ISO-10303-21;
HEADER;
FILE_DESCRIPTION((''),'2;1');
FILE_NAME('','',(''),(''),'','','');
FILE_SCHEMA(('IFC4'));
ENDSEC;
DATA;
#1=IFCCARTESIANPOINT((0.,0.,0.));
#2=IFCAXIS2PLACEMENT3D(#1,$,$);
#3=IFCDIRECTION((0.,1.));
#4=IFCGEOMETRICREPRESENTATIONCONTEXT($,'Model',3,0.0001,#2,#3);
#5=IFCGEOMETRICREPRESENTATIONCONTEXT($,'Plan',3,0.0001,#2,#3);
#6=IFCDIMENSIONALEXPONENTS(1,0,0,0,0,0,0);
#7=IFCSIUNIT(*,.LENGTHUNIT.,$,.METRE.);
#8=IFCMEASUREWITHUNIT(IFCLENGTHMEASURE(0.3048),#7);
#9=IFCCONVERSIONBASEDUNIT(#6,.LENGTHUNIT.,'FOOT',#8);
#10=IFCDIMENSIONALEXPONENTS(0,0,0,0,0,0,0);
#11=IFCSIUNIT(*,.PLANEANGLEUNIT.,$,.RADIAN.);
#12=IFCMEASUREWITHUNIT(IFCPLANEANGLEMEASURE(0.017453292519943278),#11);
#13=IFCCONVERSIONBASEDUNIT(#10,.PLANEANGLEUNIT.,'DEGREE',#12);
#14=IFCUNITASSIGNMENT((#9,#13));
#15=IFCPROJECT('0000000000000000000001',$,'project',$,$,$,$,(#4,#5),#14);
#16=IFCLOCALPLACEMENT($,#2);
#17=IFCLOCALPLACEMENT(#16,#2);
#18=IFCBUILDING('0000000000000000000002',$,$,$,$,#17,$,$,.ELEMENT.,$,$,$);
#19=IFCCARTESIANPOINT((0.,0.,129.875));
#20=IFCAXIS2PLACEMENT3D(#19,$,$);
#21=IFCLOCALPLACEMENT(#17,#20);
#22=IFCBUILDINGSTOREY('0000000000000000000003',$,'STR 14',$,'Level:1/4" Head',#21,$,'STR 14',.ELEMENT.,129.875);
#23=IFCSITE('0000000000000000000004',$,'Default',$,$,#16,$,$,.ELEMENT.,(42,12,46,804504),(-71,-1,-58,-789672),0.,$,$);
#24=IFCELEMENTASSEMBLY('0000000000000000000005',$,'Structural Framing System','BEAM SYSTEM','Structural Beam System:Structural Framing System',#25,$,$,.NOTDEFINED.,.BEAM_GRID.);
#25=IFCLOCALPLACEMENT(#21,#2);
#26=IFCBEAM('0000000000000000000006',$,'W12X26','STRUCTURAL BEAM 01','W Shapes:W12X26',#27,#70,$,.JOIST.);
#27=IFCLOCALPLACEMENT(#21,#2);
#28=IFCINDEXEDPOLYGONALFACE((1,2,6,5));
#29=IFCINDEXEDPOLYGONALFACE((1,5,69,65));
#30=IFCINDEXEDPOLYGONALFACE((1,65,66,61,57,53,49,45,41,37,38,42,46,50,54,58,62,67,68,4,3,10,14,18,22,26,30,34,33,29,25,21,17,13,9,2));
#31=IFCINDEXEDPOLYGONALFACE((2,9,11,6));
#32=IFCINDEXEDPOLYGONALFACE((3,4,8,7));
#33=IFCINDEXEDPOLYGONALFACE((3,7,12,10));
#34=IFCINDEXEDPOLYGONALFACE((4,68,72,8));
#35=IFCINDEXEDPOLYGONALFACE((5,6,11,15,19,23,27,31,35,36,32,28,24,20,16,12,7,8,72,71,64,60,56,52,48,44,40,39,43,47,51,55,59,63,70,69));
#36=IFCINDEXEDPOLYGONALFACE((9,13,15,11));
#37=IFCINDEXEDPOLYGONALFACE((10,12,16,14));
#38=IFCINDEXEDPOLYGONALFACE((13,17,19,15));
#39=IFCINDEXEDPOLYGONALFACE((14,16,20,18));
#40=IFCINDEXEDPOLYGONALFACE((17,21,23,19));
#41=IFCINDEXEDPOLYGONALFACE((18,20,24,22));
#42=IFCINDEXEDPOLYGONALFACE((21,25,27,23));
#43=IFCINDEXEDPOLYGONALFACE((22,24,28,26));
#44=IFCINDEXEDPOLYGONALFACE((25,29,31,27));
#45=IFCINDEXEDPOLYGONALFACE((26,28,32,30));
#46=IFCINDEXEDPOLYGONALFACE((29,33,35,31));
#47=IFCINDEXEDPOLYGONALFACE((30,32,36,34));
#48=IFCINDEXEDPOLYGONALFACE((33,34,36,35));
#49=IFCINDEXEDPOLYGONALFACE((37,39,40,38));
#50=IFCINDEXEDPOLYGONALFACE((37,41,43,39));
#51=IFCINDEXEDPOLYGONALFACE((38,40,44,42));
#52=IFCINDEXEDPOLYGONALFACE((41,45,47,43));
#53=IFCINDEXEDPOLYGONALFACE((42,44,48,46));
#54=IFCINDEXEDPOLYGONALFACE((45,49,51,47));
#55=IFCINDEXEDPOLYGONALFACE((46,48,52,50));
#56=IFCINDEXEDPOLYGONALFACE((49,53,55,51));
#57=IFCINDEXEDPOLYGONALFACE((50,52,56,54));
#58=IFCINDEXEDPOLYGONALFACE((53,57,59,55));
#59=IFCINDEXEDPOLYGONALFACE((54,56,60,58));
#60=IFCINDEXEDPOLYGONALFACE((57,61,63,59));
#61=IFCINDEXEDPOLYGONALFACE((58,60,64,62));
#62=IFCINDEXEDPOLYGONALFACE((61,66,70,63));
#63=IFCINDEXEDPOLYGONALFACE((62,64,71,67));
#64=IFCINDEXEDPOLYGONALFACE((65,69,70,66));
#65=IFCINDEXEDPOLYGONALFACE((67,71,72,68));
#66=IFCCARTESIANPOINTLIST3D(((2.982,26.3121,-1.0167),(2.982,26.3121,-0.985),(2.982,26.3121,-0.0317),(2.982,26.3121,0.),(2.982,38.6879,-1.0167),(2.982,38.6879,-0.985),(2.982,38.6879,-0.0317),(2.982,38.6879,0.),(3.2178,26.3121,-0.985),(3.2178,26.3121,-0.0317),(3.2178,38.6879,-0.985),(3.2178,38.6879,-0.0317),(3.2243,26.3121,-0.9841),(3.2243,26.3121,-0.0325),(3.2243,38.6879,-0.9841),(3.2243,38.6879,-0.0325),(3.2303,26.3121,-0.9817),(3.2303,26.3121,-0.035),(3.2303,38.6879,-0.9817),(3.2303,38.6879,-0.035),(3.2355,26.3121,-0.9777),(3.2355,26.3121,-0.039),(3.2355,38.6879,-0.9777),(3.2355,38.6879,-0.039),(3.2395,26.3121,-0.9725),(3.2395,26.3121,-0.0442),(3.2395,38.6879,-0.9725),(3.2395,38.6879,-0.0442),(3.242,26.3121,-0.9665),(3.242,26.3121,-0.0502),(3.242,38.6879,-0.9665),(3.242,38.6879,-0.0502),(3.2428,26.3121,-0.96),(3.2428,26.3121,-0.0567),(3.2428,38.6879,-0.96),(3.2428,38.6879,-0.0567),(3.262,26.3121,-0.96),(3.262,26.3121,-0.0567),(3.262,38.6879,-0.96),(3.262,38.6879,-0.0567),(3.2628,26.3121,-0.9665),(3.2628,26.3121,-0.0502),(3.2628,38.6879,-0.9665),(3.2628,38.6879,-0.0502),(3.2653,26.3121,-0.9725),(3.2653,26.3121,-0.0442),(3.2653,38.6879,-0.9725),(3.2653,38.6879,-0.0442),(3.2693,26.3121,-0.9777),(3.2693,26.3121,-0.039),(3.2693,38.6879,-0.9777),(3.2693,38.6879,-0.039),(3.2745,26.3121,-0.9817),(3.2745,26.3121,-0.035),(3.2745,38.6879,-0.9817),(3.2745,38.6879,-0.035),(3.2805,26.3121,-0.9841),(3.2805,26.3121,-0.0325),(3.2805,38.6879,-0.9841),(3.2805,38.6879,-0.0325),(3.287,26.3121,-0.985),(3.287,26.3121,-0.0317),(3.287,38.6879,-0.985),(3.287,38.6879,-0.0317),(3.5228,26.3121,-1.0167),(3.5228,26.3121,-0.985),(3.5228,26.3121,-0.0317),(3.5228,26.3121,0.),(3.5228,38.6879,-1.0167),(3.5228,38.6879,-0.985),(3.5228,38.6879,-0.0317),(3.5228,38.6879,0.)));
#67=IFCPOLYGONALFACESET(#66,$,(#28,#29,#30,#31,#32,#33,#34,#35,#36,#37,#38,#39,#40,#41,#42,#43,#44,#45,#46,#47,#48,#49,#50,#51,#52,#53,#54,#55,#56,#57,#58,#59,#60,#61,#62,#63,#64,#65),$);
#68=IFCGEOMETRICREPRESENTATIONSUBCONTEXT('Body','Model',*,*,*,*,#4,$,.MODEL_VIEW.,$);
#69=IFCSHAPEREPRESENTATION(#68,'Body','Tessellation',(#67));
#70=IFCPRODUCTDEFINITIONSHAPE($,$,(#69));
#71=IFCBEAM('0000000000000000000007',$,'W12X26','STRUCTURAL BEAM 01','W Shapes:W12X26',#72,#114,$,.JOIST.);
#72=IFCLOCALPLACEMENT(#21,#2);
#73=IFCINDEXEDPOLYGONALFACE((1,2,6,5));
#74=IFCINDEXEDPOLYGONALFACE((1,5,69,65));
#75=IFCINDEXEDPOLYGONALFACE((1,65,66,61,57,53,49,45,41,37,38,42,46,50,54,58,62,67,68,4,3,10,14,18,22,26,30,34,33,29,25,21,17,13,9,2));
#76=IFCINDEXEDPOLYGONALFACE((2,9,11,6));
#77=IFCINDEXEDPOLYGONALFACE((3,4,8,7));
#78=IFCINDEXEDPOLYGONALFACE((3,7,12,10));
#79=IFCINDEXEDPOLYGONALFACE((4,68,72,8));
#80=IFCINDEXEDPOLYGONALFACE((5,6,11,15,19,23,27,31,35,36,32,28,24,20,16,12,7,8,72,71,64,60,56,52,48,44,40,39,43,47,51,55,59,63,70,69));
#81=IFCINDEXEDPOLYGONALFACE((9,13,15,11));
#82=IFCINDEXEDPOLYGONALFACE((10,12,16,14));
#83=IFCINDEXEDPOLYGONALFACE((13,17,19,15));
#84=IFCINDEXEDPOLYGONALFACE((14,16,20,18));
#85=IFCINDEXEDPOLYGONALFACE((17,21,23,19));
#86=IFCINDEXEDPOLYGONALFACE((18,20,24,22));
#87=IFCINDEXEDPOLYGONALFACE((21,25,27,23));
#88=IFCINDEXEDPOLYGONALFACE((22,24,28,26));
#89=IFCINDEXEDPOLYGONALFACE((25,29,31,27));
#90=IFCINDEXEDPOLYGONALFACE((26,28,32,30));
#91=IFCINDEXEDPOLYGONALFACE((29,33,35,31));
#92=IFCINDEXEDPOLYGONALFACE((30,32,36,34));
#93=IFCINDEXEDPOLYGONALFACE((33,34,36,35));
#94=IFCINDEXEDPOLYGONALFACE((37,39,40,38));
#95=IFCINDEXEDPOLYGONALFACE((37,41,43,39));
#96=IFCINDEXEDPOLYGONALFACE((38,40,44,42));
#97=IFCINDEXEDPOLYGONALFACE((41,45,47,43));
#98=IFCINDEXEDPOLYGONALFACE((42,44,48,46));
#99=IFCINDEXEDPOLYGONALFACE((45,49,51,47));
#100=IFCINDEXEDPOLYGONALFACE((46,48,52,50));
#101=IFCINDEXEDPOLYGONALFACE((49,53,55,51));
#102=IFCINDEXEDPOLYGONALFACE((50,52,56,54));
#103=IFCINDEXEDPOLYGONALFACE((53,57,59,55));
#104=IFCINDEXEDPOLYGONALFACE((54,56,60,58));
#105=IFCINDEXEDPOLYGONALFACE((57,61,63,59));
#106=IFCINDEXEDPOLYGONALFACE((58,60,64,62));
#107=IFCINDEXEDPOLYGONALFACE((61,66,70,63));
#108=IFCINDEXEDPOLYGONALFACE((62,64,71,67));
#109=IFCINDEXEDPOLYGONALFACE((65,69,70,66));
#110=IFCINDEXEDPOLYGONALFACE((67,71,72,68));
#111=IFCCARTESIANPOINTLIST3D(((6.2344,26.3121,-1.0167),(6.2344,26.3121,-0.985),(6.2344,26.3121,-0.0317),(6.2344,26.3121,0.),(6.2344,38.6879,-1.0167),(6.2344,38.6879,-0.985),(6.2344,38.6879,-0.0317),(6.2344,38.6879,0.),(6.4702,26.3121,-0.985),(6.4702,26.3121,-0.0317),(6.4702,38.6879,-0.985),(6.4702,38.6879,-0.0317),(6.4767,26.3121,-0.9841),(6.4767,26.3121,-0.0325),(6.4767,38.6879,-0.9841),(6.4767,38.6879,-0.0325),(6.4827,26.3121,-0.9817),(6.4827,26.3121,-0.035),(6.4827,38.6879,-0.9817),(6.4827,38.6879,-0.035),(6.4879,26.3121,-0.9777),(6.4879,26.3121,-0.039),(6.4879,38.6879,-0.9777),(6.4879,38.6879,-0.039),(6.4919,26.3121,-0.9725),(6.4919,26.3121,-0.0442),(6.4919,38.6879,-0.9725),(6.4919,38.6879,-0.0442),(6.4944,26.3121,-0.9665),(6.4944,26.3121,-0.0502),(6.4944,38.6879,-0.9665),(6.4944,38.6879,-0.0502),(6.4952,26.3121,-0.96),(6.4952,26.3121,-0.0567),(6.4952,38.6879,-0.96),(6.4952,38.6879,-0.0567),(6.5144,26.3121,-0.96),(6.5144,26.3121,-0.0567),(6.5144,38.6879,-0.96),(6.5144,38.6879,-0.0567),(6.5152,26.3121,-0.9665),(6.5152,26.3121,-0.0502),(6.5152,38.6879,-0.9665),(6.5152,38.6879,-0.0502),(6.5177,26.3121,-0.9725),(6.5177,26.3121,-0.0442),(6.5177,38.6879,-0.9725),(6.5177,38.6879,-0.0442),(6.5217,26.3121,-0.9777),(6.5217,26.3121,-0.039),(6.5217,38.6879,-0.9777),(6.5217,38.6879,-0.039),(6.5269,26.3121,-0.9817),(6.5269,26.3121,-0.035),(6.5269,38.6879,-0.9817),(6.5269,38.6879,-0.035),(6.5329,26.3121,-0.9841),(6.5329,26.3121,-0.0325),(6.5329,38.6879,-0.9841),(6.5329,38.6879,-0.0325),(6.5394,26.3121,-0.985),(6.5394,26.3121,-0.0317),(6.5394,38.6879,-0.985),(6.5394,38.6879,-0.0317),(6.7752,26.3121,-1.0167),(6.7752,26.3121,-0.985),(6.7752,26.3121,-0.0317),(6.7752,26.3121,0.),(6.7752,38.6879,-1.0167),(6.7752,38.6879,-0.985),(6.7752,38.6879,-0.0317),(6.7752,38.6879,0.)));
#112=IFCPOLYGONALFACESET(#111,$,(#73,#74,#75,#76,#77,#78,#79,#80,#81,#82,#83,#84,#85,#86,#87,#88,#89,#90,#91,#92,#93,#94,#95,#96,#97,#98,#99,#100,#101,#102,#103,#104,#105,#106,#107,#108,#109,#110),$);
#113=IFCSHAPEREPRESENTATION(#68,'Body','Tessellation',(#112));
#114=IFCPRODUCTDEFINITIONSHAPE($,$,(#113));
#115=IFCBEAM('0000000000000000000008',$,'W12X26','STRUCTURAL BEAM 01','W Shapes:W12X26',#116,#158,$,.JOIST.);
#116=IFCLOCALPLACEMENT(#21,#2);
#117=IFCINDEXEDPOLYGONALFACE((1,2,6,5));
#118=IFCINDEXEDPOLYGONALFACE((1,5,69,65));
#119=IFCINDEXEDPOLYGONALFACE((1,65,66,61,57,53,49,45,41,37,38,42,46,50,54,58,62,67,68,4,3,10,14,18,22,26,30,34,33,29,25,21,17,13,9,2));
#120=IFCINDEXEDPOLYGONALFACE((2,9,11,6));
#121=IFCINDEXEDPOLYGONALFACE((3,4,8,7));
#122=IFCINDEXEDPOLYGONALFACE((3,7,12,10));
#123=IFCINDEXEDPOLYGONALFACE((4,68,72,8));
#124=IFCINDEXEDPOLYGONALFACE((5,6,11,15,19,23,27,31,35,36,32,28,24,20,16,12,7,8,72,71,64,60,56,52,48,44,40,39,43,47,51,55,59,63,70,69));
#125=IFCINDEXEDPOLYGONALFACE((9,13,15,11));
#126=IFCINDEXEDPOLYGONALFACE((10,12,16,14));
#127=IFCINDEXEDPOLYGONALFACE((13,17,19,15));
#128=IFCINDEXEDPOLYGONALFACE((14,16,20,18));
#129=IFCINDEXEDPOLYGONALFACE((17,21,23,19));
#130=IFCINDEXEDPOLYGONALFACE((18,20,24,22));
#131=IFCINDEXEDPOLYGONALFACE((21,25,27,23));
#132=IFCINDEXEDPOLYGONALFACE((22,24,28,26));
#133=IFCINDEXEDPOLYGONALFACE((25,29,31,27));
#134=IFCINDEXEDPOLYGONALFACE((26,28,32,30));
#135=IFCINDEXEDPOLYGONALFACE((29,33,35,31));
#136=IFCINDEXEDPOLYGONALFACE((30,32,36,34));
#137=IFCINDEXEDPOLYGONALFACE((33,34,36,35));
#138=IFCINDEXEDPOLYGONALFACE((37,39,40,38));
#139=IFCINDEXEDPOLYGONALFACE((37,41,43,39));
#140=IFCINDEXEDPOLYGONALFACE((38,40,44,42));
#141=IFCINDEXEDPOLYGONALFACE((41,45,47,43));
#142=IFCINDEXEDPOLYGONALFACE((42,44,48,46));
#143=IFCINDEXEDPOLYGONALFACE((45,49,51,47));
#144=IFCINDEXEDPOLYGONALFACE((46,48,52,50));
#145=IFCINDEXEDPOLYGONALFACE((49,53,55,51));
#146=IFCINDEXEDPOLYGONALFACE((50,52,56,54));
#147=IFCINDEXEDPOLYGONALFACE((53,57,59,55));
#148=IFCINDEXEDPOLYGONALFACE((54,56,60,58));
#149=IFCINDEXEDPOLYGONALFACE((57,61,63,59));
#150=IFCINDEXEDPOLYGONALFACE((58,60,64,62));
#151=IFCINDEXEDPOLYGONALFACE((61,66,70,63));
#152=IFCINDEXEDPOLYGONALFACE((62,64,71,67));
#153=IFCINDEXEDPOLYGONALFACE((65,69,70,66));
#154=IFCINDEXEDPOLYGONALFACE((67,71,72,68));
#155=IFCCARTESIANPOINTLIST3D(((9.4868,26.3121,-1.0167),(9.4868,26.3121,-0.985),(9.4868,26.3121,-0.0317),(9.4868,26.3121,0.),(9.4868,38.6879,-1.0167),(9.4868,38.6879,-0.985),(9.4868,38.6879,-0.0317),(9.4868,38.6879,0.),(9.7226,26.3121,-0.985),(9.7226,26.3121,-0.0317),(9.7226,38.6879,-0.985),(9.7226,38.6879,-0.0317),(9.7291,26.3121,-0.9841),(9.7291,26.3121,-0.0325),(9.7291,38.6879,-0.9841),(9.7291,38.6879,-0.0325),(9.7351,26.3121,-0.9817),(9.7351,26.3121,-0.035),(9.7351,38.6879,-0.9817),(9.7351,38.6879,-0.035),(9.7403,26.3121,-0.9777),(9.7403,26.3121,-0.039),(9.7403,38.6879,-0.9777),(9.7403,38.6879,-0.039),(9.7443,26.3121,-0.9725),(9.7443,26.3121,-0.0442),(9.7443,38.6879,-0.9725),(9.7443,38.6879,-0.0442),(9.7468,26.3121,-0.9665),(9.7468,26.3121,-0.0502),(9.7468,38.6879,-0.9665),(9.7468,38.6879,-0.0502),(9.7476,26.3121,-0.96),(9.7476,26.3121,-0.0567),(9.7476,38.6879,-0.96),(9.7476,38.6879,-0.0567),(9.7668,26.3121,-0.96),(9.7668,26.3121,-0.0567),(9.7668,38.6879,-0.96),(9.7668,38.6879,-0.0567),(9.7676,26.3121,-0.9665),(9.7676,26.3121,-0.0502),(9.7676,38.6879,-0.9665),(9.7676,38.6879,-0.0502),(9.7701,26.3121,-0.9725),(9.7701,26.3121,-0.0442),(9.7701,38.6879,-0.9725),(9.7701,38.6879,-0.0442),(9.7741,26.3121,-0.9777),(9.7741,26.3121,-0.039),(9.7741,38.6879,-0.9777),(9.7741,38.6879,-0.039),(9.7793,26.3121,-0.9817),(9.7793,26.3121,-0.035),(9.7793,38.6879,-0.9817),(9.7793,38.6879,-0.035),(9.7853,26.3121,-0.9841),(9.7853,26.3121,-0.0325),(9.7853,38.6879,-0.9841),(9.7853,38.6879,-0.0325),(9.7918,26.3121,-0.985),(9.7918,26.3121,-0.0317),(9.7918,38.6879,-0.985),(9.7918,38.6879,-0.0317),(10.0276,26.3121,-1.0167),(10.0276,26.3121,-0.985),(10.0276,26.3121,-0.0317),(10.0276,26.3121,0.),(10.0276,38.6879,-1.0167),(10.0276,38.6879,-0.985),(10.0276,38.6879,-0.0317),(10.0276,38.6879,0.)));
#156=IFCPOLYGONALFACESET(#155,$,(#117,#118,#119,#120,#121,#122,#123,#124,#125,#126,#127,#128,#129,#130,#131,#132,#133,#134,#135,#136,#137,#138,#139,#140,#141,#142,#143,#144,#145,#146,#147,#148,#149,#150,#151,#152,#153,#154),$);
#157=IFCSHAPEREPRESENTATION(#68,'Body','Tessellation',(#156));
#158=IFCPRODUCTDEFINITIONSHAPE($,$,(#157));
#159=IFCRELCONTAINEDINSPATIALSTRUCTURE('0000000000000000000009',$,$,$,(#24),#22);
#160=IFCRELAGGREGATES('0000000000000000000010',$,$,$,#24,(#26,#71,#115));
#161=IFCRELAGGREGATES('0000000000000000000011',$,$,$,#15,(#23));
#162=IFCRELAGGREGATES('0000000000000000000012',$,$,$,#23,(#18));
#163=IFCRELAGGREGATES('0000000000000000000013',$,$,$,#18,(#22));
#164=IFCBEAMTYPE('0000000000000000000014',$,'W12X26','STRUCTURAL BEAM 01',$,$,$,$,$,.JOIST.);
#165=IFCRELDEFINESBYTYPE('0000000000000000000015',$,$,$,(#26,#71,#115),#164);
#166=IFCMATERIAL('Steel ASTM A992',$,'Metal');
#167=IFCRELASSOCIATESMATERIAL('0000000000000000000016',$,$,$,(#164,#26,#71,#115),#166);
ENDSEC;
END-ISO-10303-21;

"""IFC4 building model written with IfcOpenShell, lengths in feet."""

from ifc_helpers import new_model, entity, si_unit, converted_unit, direction, frame, origin, place, context, subcontext, project, spatial, line, arc, indexed_curve, outline, extrude, source, transform, mapped, material, type_object, type_shapes, element, aggregate, save


model = new_model("IFC4")

# Units and contexts
model_context = context("Model", 3, precision=0.0001, world=origin(), true_north=direction((0.0, 1.0)))
plan_context = context("Plan", 3, precision=0.0001, world=origin(), true_north=direction((0.0, 1.0)))
body_context = subcontext(model_context, "Body", "Model", "MODEL_VIEW")
ifc_project = project(units=[converted_unit("LENGTHUNIT", "FOOT", entity("IfcLengthMeasure", 0.3048), si_unit("LENGTHUNIT", "METRE"), dimensions=[1, 0, 0, 0, 0, 0, 0]), converted_unit("PLANEANGLEUNIT", "DEGREE", entity("IfcPlaneAngleMeasure", 0.017453292519943278), si_unit("PLANEANGLEUNIT", "RADIAN"), dimensions=[0, 0, 0, 0, 0, 0, 0])], contexts=[model_context, plan_context])

# Site, building, storey
site_placement = place(None, origin())
site = spatial("IfcSite", under=ifc_project, at=site_placement, Name="Default", CompositionType="ELEMENT", RefLatitude=(42, 12, 46, 804504), RefLongitude=(-71, -1, -58, -789672), RefElevation=0.0)
building_placement = place(site_placement, origin())
building = spatial("IfcBuilding", under=site, at=building_placement, CompositionType="ELEMENT")
storey_placement = place(building_placement, frame((0.0, 0.0, 129.875)))
storey = spatial("IfcBuildingStorey", under=building, at=storey_placement, Name="STR 14", ObjectType="Level:1/4\" Head", LongName="STR 14", CompositionType="ELEMENT", Elevation=129.875)

# Shared definitions
ifc_material = material(Name="Steel ASTM A992", Category="Metal")

# Element assembly, beams
beam_type_1 = type_object("IfcBeamType", Name="W12X26", Description="STRUCTURAL BEAM 01", PredefinedType="JOIST", material=ifc_material)
shared_shape_1 = source(origin(), body_context, "Body", "SweptSolid", [
    extrude(outline(indexed_curve([(-0.2704, -0.4767), (-0.2704, -0.5083), (0.2704, -0.5083), (0.2704, -0.4767), (0.0346, -0.4767), (0.0169, -0.4693), (0.0096, -0.4517), (0.0096, 0.4517), (0.0169, 0.4693), (0.0346, 0.4767), (0.2704, 0.4767), (0.2704, 0.5083), (-0.2704, 0.5083), (-0.2704, 0.4767), (-0.0346, 0.4767), (-0.0169, 0.4693), (-0.0096, 0.4517), (-0.0096, -0.4517), (-0.0169, -0.4693), (-0.0346, -0.4767)], segments=[line(1, 2, 3, 4, 5), arc(5, 6, 7), line(7, 8), arc(8, 9, 10), line(10, 11, 12, 13, 14, 15), arc(15, 16, 17), line(17, 18), arc(18, 19, 20), line(20, 1)], self_intersect=False)), frame((-6.1879, 0.0, 0.0), z_axis=(-1.0, 0.0, 0.0), x_axis=(0.0, -1.0, 0.0)), (0.0, 0.0, -1.0), 12.3758),
])
type_shapes(beam_type_1, [shared_shape_1])
assembly_1_placement = place(storey_placement, origin())
assembly_1 = element("IfcElementAssembly", 1, at=assembly_1_placement, inside=storey, Name="Structural Framing System", Description="BEAM SYSTEM", ObjectType="Structural Beam System:Structural Framing System", AssemblyPlace="NOTDEFINED", PredefinedType="BEAM_GRID")
beam_1_placement = place(assembly_1_placement, frame((3.2524, 32.5, -0.5083), z_axis=(0.0, 0.0, 1.0), x_axis=(0.0, 1.0, 0.0)))
beam_1 = element("IfcBeam", 2, at=beam_1_placement, type_object=beam_type_1, material=ifc_material, Name="W12X26", Description="STRUCTURAL BEAM 01", ObjectType="W Shapes:W12X26", PredefinedType="JOIST", context=body_context, shape_type="MappedRepresentation", body=[
    mapped(shared_shape_1, transform((0.0, 0.0, 0.0), scale=1.0)),
])
beam_2_placement = place(assembly_1_placement, frame((6.5048, 32.5, -0.5083), z_axis=(0.0, 0.0, 1.0), x_axis=(0.0, 1.0, 0.0)))
beam_2 = element("IfcBeam", 3, at=beam_2_placement, type_object=beam_type_1, material=ifc_material, Name="W12X26", Description="STRUCTURAL BEAM 01", ObjectType="W Shapes:W12X26", PredefinedType="JOIST", context=body_context, shape_type="MappedRepresentation", body=[
    mapped(shared_shape_1, transform((0.0, 0.0, 0.0), scale=1.0)),
])
beam_3_placement = place(assembly_1_placement, frame((9.7572, 32.5, -0.5083), z_axis=(0.0, 0.0, 1.0), x_axis=(0.0, 1.0, 0.0)))
beam_3 = element("IfcBeam", 4, at=beam_3_placement, type_object=beam_type_1, material=ifc_material, Name="W12X26", Description="STRUCTURAL BEAM 01", ObjectType="W Shapes:W12X26", PredefinedType="JOIST", context=body_context, shape_type="MappedRepresentation", body=[
    mapped(shared_shape_1, transform((0.0, 0.0, 0.0), scale=1.0)),
])
aggregate(assembly_1, [beam_1, beam_2, beam_3])

save(model, "model.ifc")
